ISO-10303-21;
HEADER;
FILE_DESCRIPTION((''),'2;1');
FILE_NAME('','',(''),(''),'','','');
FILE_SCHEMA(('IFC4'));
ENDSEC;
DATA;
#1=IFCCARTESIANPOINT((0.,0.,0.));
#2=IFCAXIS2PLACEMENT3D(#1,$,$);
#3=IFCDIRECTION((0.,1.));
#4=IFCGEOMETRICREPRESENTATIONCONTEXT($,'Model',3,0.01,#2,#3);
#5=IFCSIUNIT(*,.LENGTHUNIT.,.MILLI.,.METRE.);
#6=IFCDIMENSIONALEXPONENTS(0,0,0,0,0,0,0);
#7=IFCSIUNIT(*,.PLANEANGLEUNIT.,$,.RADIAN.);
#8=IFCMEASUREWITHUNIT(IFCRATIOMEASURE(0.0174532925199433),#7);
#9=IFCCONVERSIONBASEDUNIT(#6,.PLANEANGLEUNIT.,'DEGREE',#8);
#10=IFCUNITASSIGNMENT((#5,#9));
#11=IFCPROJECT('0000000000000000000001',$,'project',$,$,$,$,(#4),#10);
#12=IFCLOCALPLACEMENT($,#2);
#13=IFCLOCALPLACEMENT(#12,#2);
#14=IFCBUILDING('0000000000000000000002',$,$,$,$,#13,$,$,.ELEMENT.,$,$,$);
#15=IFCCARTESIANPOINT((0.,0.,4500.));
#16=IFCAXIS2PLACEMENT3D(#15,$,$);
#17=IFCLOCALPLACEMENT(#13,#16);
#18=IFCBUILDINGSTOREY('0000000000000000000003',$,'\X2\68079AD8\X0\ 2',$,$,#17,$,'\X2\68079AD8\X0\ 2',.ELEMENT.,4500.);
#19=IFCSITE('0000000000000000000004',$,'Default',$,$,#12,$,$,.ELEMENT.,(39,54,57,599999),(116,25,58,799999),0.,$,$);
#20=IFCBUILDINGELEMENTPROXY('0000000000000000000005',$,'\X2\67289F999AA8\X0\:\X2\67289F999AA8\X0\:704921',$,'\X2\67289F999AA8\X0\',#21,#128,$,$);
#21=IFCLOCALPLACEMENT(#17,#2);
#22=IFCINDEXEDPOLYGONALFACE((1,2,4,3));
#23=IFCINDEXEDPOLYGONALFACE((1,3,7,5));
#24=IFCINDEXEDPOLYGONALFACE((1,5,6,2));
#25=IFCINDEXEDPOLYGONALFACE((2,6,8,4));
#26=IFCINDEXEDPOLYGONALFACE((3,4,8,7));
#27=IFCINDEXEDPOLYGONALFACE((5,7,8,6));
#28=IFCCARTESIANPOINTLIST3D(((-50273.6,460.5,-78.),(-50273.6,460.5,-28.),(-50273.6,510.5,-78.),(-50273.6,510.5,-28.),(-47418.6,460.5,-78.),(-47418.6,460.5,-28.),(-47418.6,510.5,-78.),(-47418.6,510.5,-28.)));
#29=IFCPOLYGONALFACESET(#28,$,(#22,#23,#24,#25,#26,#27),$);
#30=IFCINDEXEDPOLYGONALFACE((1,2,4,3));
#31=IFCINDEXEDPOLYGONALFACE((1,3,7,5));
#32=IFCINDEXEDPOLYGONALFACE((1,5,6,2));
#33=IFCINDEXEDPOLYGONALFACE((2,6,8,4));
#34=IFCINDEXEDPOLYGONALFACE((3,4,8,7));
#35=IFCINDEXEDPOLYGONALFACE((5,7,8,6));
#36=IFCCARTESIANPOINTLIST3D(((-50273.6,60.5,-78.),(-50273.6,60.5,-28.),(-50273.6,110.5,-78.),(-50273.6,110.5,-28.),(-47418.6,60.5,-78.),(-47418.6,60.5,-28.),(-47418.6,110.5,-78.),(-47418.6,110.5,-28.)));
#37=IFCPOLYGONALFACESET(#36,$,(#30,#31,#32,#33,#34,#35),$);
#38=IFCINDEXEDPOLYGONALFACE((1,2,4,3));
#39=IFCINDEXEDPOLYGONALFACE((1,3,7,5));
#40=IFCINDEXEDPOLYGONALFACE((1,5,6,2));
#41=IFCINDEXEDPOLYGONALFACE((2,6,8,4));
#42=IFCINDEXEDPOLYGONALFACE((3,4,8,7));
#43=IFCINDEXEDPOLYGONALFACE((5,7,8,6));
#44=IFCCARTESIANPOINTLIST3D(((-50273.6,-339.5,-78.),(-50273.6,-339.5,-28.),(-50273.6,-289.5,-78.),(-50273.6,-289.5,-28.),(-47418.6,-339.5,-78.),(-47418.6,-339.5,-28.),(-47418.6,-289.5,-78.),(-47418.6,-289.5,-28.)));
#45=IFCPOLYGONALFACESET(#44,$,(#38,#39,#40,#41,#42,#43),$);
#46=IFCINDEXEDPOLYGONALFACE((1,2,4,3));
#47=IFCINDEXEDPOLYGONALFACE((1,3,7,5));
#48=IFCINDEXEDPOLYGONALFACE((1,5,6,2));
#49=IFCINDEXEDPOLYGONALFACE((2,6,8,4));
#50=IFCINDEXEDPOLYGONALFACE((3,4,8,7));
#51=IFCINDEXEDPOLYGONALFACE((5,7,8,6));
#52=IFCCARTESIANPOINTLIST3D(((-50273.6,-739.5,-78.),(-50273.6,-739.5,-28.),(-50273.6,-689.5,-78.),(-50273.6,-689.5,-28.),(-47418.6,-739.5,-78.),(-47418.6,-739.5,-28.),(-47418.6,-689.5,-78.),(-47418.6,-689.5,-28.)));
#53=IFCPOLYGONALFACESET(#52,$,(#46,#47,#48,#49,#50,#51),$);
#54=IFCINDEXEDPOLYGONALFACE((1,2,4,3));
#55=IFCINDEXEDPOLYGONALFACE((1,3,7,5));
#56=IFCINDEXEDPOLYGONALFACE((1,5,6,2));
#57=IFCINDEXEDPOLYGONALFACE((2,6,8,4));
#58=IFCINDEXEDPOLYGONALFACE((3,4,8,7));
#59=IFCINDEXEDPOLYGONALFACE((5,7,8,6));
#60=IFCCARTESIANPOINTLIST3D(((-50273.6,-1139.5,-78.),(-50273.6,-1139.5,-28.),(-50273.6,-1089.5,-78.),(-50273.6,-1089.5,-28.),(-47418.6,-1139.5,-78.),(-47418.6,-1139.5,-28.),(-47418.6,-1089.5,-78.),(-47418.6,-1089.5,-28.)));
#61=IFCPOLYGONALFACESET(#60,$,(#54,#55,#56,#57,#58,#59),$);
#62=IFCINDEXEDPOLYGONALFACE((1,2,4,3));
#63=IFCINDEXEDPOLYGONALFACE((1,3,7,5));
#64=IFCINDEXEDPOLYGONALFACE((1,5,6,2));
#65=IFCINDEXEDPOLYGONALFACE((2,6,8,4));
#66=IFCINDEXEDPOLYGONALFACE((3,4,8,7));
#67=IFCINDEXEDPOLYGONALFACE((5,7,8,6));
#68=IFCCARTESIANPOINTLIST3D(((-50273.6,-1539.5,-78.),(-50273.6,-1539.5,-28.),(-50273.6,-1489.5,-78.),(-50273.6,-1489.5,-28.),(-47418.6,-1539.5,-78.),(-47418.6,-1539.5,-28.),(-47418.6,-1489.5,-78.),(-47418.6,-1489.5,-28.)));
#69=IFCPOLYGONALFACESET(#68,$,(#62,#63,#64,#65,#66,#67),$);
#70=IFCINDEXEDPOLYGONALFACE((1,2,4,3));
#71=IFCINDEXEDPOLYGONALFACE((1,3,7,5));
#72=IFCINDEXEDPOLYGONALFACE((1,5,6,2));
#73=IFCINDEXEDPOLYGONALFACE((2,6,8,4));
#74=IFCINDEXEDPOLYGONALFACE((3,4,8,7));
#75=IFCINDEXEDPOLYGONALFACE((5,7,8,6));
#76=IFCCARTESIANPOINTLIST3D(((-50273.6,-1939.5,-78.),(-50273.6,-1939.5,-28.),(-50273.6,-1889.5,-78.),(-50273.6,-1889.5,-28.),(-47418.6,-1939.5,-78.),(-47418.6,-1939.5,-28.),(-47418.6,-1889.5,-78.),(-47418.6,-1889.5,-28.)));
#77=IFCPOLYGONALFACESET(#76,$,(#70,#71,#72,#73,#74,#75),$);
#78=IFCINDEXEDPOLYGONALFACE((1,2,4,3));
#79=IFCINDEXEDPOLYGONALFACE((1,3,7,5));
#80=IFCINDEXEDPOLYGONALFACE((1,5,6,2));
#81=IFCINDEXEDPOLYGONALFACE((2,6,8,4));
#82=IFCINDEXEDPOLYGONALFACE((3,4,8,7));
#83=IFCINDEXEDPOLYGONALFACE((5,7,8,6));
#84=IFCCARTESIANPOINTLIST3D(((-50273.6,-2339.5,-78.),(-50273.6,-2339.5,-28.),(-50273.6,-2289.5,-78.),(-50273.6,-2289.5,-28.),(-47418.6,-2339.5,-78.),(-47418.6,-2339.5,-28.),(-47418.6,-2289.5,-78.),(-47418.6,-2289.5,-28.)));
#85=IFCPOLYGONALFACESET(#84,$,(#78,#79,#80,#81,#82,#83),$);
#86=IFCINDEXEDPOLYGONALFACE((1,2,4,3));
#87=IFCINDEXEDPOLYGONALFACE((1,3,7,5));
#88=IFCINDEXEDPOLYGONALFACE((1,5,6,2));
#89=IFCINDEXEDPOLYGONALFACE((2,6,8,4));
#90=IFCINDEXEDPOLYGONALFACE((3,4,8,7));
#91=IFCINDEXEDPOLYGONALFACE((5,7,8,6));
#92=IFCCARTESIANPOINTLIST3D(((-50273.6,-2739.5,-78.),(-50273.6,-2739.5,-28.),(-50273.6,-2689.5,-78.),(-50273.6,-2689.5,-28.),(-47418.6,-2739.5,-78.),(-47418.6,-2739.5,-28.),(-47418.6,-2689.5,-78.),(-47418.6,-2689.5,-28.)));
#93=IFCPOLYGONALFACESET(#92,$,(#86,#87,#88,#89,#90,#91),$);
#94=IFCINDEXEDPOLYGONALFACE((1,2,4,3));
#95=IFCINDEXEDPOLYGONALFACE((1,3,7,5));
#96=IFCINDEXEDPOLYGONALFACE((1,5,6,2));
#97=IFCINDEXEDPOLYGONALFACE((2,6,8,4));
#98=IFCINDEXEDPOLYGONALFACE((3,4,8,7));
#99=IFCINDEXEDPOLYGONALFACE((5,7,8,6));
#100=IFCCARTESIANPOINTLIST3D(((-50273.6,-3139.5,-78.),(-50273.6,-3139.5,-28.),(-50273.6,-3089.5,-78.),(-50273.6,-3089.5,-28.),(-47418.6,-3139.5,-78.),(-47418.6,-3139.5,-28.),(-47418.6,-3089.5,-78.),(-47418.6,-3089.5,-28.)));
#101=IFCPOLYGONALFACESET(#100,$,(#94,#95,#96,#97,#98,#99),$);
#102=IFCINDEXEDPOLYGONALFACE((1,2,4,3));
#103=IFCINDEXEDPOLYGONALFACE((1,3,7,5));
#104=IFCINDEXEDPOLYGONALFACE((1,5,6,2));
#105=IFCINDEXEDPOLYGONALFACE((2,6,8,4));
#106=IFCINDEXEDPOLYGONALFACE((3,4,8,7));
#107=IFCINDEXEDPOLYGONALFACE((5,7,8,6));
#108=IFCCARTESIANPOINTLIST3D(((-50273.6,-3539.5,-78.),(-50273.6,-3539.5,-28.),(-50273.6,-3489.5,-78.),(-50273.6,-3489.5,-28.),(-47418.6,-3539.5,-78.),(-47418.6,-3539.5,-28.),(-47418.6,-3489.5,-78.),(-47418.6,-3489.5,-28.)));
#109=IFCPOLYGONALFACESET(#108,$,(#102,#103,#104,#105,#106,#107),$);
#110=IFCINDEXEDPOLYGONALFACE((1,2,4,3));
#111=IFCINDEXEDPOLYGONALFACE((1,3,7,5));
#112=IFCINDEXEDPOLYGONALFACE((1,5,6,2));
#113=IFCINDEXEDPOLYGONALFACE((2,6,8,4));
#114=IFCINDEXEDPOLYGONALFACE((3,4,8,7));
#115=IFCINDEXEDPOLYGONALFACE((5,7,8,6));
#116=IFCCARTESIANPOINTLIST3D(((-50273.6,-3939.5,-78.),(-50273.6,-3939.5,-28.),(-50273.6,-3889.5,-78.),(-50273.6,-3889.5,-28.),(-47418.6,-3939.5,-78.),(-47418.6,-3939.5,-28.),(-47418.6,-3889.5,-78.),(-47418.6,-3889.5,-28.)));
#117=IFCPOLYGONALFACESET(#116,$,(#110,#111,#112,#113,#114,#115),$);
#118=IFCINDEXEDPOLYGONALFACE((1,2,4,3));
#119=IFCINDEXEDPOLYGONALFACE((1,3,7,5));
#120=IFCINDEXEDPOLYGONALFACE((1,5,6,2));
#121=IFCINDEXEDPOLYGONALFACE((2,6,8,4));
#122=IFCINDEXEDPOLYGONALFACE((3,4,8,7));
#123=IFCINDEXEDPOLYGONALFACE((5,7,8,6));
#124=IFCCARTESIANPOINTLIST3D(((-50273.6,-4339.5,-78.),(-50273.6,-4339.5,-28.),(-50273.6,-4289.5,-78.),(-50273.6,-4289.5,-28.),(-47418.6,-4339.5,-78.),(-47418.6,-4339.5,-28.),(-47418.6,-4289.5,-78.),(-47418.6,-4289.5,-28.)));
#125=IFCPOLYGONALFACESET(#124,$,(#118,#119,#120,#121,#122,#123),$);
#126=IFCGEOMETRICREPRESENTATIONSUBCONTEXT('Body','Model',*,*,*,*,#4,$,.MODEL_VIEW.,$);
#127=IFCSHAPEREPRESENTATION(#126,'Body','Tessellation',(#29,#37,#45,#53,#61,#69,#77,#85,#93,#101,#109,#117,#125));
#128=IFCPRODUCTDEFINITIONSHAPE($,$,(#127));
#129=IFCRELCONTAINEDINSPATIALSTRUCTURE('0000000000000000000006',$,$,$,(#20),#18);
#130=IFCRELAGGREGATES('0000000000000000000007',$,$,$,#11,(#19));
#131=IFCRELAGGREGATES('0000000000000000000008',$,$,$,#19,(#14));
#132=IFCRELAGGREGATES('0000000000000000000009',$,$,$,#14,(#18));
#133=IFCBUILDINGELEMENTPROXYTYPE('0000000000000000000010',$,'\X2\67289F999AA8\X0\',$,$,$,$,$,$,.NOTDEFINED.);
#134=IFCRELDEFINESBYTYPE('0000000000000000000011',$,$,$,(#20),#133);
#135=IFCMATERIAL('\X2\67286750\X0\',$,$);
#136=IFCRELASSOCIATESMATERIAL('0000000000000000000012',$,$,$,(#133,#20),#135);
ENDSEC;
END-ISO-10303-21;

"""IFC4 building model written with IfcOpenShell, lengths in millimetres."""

from ifc_helpers import new_model, entity, si_unit, converted_unit, direction, frame, frame_2d, origin, origin_2d_with_axis, place, context, subcontext, project, spatial, rectangle, extrude, source, transform, mapped, material, type_object, type_shapes, element, save


model = new_model("IFC4")

# Units and contexts
model_context = context("Model", 3, precision=0.01, world=origin(), true_north=direction((0.0, 1.0)))
body_context = subcontext(model_context, "Body", "Model", "MODEL_VIEW")
ifc_project = project(units=[si_unit("LENGTHUNIT", "METRE", prefix="MILLI"), converted_unit("PLANEANGLEUNIT", "DEGREE", entity("IfcRatioMeasure", 0.0174532925199433), si_unit("PLANEANGLEUNIT", "RADIAN"), dimensions=[0, 0, 0, 0, 0, 0, 0])], contexts=[model_context])

# Site, building, storey
site_placement = place(None, origin())
site = spatial("IfcSite", under=ifc_project, at=site_placement, Name="Default", CompositionType="ELEMENT", RefLatitude=(39, 54, 57, 599999), RefLongitude=(116, 25, 58, 799999), RefElevation=0.0)
building_placement = place(site_placement, origin())
building = spatial("IfcBuilding", under=site, at=building_placement, CompositionType="ELEMENT")
storey_placement = place(building_placement, frame((0.0, 0.0, 4500.0)))
storey = spatial("IfcBuildingStorey", under=building, at=storey_placement, Name="标高 2", LongName="标高 2", CompositionType="ELEMENT", Elevation=4500.0)

# Building element proxy
ifc_material_1 = material(Name="木材")
building_element_proxy_type_1 = type_object("IfcBuildingElementProxyType", Name="木龙骨", PredefinedType="NOTDEFINED", material=ifc_material_1)
shared_shape_1 = source(origin(), body_context, "Body", "SweptSolid", [
    extrude(rectangle(XDim=2855.0, YDim=50.0, at=origin_2d_with_axis()), frame((1427.5, 4825.0, 0.0), z_axis=(0.0, 0.0, 1.0), x_axis=(-1.0, 0.0, 0.0)), (0.0, 0.0, 1.0), 50.0),
    extrude(rectangle(XDim=2855.0, YDim=50.0, at=origin_2d_with_axis()), frame((1427.5, 4425.0, 0.0), z_axis=(0.0, 0.0, 1.0), x_axis=(-1.0, 0.0, 0.0)), (0.0, 0.0, 1.0), 50.0),
    extrude(rectangle(XDim=2855.0, YDim=50.0, at=origin_2d_with_axis()), frame((1427.5, 4025.0, 0.0), z_axis=(0.0, 0.0, 1.0), x_axis=(-1.0, 0.0, 0.0)), (0.0, 0.0, 1.0), 50.0),
    extrude(rectangle(XDim=2855.0, YDim=50.0, at=frame_2d((0.0, 0.0), x_axis=(1.0, 0.0))), frame((1427.5, 3625.0, 0.0), z_axis=(0.0, 0.0, 1.0), x_axis=(-1.0, 0.0, 0.0)), (0.0, 0.0, 1.0), 50.0),
    extrude(rectangle(XDim=2855.0, YDim=50.0, at=origin_2d_with_axis()), frame((1427.5, 3225.0, 0.0), z_axis=(0.0, 0.0, 1.0), x_axis=(-1.0, 0.0, 0.0)), (0.0, 0.0, 1.0), 50.0),
    extrude(rectangle(XDim=2855.0, YDim=50.0, at=origin_2d_with_axis()), frame((1427.5, 2825.0, 0.0), z_axis=(0.0, 0.0, 1.0), x_axis=(-1.0, 0.0, 0.0)), (0.0, 0.0, 1.0), 50.0),
    extrude(rectangle(XDim=2855.0, YDim=50.0, at=origin_2d_with_axis()), frame((1427.5, 2425.0, 0.0), z_axis=(0.0, 0.0, 1.0), x_axis=(-1.0, 0.0, 0.0)), (0.0, 0.0, 1.0), 50.0),
    extrude(rectangle(XDim=2855.0, YDim=50.0, at=origin_2d_with_axis()), frame((1427.5, 2025.0, 0.0), z_axis=(0.0, 0.0, 1.0), x_axis=(-1.0, 0.0, 0.0)), (0.0, 0.0, 1.0), 50.0),
    extrude(rectangle(XDim=2855.0, YDim=50.0, at=origin_2d_with_axis()), frame((1427.5, 1625.0, 0.0), z_axis=(0.0, 0.0, 1.0), x_axis=(-1.0, 0.0, 0.0)), (0.0, 0.0, 1.0), 50.0),
    extrude(rectangle(XDim=2855.0, YDim=50.0, at=origin_2d_with_axis()), frame((1427.5, 1225.0, 0.0), z_axis=(0.0, 0.0, 1.0), x_axis=(-1.0, 0.0, 0.0)), (0.0, 0.0, 1.0), 50.0),
    extrude(rectangle(XDim=2855.0, YDim=50.0, at=origin_2d_with_axis()), frame((1427.5, 825.0, 0.0), z_axis=(0.0, 0.0, 1.0), x_axis=(-1.0, 0.0, 0.0)), (0.0, 0.0, 1.0), 50.0),
    extrude(rectangle(XDim=2855.0, YDim=50.0, at=origin_2d_with_axis()), frame((1427.5, 425.0, 0.0), z_axis=(0.0, 0.0, 1.0), x_axis=(-1.0, 0.0, 0.0)), (0.0, 0.0, 1.0), 50.0),
    extrude(rectangle(XDim=2855.0, YDim=50.0, at=origin_2d_with_axis()), frame((1427.5, 25.0, 0.0), z_axis=(0.0, 0.0, 1.0), x_axis=(-1.0, 0.0, 0.0)), (0.0, 0.0, 1.0), 50.0),
])
type_shapes(building_element_proxy_type_1, [shared_shape_1])
proxy_1_placement = place(storey_placement, frame((-50273.6, -4339.5, -78.0)))
element("IfcBuildingElementProxy", 1, at=proxy_1_placement, inside=storey, type_object=building_element_proxy_type_1, material=ifc_material_1, Name="木龙骨:木龙骨:704921", ObjectType="木龙骨", context=body_context, shape_type="MappedRepresentation", body=[
    mapped(shared_shape_1, transform((0.0, 0.0, 0.0), scale=1.0)),
])

save(model, "model.ifc")
